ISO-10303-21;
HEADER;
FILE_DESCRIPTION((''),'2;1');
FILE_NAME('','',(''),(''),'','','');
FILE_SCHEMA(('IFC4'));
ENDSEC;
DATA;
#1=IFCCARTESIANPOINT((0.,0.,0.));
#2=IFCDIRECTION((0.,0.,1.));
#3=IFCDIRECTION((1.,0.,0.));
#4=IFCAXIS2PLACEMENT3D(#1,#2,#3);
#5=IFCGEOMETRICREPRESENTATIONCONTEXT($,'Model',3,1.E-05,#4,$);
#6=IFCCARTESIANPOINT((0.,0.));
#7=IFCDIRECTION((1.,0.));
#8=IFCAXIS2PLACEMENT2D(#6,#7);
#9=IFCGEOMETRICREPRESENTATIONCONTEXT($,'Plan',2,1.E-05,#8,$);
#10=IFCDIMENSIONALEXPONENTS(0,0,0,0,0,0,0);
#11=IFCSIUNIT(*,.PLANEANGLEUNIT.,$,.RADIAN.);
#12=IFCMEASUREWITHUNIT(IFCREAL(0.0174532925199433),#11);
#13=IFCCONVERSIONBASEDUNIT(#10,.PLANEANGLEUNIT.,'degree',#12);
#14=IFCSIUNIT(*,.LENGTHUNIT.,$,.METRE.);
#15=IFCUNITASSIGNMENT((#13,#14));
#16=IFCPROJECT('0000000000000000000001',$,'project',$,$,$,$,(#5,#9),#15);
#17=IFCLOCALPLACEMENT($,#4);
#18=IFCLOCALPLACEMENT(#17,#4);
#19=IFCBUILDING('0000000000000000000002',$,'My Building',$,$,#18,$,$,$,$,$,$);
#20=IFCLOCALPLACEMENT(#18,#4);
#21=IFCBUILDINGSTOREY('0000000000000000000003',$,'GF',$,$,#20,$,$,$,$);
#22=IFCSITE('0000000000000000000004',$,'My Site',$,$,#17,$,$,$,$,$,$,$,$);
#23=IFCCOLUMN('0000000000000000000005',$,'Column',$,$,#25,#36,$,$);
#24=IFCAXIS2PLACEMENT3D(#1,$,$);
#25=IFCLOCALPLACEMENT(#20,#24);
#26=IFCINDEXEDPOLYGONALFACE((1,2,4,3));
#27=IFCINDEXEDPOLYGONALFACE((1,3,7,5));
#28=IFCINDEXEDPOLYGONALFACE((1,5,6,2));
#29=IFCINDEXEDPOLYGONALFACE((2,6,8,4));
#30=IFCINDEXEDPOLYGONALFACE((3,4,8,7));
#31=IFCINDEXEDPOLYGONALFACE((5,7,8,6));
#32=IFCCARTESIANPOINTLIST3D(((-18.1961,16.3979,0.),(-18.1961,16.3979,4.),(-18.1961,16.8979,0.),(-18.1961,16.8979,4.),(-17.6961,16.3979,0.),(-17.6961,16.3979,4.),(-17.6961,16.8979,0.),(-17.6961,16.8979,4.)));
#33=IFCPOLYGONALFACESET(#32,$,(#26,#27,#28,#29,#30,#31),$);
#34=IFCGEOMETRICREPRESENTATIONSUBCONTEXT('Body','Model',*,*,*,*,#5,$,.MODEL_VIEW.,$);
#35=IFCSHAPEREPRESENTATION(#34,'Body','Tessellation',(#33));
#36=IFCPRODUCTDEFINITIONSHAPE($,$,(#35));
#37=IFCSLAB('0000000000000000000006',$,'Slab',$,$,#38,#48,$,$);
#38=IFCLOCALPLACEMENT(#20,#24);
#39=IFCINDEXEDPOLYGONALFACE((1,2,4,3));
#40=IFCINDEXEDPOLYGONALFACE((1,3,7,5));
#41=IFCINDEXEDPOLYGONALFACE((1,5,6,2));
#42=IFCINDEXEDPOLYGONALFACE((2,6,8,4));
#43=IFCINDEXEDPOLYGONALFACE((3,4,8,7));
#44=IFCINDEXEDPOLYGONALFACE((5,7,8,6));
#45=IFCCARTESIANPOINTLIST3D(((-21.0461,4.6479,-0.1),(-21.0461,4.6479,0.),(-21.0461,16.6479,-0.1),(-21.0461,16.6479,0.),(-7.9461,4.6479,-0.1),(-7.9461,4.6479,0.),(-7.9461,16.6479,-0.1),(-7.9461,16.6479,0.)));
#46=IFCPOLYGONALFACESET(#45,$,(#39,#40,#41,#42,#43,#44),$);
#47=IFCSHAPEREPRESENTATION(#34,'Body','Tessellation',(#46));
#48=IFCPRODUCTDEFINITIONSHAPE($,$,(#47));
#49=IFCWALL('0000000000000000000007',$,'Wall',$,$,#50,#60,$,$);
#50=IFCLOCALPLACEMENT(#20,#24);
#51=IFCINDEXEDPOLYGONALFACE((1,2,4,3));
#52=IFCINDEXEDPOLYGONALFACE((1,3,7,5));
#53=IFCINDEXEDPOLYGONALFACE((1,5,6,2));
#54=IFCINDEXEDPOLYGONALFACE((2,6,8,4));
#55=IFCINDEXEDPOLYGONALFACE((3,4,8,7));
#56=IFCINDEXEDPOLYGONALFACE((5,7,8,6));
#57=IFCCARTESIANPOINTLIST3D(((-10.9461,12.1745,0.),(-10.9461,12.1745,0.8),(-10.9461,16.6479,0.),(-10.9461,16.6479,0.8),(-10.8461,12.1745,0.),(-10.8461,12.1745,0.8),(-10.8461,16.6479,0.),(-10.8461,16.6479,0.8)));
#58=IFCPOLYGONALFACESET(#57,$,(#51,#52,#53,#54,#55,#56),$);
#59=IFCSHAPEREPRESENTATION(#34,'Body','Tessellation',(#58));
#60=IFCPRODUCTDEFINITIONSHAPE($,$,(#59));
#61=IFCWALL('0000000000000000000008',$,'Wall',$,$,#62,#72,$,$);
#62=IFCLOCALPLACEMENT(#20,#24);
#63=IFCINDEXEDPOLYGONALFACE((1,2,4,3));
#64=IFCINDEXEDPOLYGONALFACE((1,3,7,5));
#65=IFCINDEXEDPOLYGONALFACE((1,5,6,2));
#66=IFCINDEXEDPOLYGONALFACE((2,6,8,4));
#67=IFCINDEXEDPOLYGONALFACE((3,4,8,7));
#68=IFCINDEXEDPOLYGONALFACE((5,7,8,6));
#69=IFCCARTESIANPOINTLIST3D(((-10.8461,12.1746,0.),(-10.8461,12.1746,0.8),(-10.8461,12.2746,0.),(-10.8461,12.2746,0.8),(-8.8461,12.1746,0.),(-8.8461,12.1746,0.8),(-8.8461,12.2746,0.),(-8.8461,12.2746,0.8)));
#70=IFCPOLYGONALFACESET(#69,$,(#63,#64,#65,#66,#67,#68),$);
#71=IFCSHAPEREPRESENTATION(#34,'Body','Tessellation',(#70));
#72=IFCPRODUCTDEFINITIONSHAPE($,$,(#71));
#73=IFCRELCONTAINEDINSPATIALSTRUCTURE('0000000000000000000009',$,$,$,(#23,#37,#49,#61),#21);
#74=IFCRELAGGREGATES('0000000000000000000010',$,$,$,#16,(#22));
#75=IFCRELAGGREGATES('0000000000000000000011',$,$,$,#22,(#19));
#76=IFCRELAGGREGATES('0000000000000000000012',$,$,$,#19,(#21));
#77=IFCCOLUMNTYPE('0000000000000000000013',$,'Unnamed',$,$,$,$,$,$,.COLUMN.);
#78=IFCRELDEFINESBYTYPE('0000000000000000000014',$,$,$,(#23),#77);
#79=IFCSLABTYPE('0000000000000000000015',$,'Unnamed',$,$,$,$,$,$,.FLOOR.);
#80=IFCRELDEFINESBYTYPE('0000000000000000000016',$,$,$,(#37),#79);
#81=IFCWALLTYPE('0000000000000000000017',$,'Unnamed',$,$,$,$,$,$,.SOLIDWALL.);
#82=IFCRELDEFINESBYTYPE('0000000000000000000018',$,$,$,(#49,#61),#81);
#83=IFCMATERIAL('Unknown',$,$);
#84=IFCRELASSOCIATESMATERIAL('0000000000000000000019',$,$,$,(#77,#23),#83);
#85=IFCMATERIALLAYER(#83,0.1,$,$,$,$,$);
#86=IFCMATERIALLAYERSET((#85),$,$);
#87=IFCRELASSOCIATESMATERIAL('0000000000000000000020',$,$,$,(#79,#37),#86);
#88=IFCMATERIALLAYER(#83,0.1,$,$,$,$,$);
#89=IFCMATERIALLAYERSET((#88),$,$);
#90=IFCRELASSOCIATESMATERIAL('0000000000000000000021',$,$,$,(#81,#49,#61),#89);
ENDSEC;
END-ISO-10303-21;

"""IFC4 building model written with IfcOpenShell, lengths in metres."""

from ifc_helpers import new_model, entity, si_unit, converted_unit, frame, origin_with_axes, origin_2d_with_axis, place, context, subcontext, project, spatial, line, indexed_curve, rectangle, outline, extrude, material, layer, layer_set, layer_usage, material_profile, profile_set, profile_usage, type_object, element, save


model = new_model("IFC4")

# Units and contexts
model_context = context("Model", 3, precision=1e-05, world=origin_with_axes())
plan_context = context("Plan", 2, precision=1e-05, world=origin_2d_with_axis())
body_context_1 = subcontext(model_context, "Body", "Model", "MODEL_VIEW")
ifc_project = project(units=[converted_unit("PLANEANGLEUNIT", "degree", entity("IfcReal", 0.0174532925199433), si_unit("PLANEANGLEUNIT", "RADIAN"), dimensions=[0, 0, 0, 0, 0, 0, 0]), si_unit("LENGTHUNIT", "METRE")], contexts=[model_context, plan_context])

# Site, building, storey
site_placement = place(None, origin_with_axes())
site = spatial("IfcSite", under=ifc_project, at=site_placement, Name="My Site")
building_placement = place(site_placement, origin_with_axes())
building = spatial("IfcBuilding", under=site, at=building_placement, Name="My Building")
storey_placement = place(building_placement, origin_with_axes())
storey = spatial("IfcBuildingStorey", under=building, at=storey_placement, Name="GF")

# Column
ifc_material = material(Name="Unknown")
ifc_material_profile = material_profile(ifc_material, rectangle(XDim=0.5, YDim=0.5))
ifc_profile_set = profile_set([ifc_material_profile])
ifc_profile_usage = profile_usage(ifc_profile_set, cardinal=5)
column_type = type_object("IfcColumnType", Name="Unnamed", PredefinedType="COLUMN", material=ifc_profile_set)
column_placement = place(storey_placement, frame((-17.9461, 16.6479, 0.0), z_axis=(0.0, 0.0, 1.0), x_axis=(1.0, 0.0, 0.0)))
element("IfcColumn", 1, at=column_placement, inside=storey, type_object=column_type, material=ifc_profile_usage, Name="Column", context=body_context_1, shape_type="SweptSolid", body=[
    extrude(rectangle(XDim=0.5, YDim=0.5), origin_with_axes(), (0.0, 0.0, 1.0), 4.0),
])

# Slab
ifc_layer_1 = layer(ifc_material, 0.1)
ifc_layer_set_1 = layer_set([ifc_layer_1])
ifc_layer_usage_1 = layer_usage(ifc_layer_set_1, "AXIS3", "POSITIVE", -0.1)
slab_type = type_object("IfcSlabType", Name="Unnamed", PredefinedType="FLOOR", material=ifc_layer_set_1)
slab_placement = place(storey_placement, frame((-21.0461, 16.6479, 0.0), z_axis=(0.0, 0.0, 1.0), x_axis=(1.0, 0.0, 0.0)))
element("IfcSlab", 2, at=slab_placement, inside=storey, type_object=slab_type, material=ifc_layer_usage_1, Name="Slab", context=body_context_1, shape_type="SweptSolid", body=[
    extrude(outline(indexed_curve([(0.0, 0.0), (13.1, 0.0), (13.1, -12.0), (0.0, -12.0), (0.0, 0.0)])), frame((0.0, 0.0, -0.1), z_axis=(0.0, 0.0, 1.0), x_axis=(1.0, 0.0, 0.0)), (0.0, 0.0, 1.0), 0.1),
])

# Shared definitions
ifc_layer_2 = layer(ifc_material, 0.1)
ifc_layer_set_2 = layer_set([ifc_layer_2])
wall_type = type_object("IfcWallType", Name="Unnamed", PredefinedType="SOLIDWALL", material=ifc_layer_set_2)

# Walls
ifc_layer_usage_2 = layer_usage(ifc_layer_set_2, "AXIS2", "POSITIVE", 0.0)
wall_1_placement = place(storey_placement, frame((-10.8461, 12.1745, 0.0), z_axis=(0.0, 0.0, 1.0), x_axis=(0.0, 1.0, 0.0)))
element("IfcWall", 3, at=wall_1_placement, inside=storey, type_object=wall_type, material=ifc_layer_usage_2, Name="Wall", context=body_context_1, shape_type="SweptSolid", body=[
    extrude(outline(indexed_curve([(0.0, 0.0), (0.0, 0.1), (4.4734, 0.1), (4.4734, 0.0)], segments=[line(1, 2, 3, 4, 1)])), origin_with_axes(), (0.0, 0.0, 1.0), 0.8),
])
ifc_layer_usage_3 = layer_usage(ifc_layer_set_2, "AXIS2", "POSITIVE", 0.0)
wall_2_placement = place(storey_placement, frame((-10.8461, 12.1746, 0.0), z_axis=(0.0, 0.0, 1.0), x_axis=(1.0, 0.0, 0.0)))
element("IfcWall", 4, at=wall_2_placement, inside=storey, type_object=wall_type, material=ifc_layer_usage_3, Name="Wall", context=body_context_1, shape_type="SweptSolid", body=[
    extrude(outline(indexed_curve([(0.0, 0.0), (0.0, 0.1), (2.0, 0.1), (2.0, 0.0)], segments=[line(1, 2, 3, 4, 1)])), origin_with_axes(), (0.0, 0.0, 1.0), 0.8),
])

save(model, "model.ifc")
